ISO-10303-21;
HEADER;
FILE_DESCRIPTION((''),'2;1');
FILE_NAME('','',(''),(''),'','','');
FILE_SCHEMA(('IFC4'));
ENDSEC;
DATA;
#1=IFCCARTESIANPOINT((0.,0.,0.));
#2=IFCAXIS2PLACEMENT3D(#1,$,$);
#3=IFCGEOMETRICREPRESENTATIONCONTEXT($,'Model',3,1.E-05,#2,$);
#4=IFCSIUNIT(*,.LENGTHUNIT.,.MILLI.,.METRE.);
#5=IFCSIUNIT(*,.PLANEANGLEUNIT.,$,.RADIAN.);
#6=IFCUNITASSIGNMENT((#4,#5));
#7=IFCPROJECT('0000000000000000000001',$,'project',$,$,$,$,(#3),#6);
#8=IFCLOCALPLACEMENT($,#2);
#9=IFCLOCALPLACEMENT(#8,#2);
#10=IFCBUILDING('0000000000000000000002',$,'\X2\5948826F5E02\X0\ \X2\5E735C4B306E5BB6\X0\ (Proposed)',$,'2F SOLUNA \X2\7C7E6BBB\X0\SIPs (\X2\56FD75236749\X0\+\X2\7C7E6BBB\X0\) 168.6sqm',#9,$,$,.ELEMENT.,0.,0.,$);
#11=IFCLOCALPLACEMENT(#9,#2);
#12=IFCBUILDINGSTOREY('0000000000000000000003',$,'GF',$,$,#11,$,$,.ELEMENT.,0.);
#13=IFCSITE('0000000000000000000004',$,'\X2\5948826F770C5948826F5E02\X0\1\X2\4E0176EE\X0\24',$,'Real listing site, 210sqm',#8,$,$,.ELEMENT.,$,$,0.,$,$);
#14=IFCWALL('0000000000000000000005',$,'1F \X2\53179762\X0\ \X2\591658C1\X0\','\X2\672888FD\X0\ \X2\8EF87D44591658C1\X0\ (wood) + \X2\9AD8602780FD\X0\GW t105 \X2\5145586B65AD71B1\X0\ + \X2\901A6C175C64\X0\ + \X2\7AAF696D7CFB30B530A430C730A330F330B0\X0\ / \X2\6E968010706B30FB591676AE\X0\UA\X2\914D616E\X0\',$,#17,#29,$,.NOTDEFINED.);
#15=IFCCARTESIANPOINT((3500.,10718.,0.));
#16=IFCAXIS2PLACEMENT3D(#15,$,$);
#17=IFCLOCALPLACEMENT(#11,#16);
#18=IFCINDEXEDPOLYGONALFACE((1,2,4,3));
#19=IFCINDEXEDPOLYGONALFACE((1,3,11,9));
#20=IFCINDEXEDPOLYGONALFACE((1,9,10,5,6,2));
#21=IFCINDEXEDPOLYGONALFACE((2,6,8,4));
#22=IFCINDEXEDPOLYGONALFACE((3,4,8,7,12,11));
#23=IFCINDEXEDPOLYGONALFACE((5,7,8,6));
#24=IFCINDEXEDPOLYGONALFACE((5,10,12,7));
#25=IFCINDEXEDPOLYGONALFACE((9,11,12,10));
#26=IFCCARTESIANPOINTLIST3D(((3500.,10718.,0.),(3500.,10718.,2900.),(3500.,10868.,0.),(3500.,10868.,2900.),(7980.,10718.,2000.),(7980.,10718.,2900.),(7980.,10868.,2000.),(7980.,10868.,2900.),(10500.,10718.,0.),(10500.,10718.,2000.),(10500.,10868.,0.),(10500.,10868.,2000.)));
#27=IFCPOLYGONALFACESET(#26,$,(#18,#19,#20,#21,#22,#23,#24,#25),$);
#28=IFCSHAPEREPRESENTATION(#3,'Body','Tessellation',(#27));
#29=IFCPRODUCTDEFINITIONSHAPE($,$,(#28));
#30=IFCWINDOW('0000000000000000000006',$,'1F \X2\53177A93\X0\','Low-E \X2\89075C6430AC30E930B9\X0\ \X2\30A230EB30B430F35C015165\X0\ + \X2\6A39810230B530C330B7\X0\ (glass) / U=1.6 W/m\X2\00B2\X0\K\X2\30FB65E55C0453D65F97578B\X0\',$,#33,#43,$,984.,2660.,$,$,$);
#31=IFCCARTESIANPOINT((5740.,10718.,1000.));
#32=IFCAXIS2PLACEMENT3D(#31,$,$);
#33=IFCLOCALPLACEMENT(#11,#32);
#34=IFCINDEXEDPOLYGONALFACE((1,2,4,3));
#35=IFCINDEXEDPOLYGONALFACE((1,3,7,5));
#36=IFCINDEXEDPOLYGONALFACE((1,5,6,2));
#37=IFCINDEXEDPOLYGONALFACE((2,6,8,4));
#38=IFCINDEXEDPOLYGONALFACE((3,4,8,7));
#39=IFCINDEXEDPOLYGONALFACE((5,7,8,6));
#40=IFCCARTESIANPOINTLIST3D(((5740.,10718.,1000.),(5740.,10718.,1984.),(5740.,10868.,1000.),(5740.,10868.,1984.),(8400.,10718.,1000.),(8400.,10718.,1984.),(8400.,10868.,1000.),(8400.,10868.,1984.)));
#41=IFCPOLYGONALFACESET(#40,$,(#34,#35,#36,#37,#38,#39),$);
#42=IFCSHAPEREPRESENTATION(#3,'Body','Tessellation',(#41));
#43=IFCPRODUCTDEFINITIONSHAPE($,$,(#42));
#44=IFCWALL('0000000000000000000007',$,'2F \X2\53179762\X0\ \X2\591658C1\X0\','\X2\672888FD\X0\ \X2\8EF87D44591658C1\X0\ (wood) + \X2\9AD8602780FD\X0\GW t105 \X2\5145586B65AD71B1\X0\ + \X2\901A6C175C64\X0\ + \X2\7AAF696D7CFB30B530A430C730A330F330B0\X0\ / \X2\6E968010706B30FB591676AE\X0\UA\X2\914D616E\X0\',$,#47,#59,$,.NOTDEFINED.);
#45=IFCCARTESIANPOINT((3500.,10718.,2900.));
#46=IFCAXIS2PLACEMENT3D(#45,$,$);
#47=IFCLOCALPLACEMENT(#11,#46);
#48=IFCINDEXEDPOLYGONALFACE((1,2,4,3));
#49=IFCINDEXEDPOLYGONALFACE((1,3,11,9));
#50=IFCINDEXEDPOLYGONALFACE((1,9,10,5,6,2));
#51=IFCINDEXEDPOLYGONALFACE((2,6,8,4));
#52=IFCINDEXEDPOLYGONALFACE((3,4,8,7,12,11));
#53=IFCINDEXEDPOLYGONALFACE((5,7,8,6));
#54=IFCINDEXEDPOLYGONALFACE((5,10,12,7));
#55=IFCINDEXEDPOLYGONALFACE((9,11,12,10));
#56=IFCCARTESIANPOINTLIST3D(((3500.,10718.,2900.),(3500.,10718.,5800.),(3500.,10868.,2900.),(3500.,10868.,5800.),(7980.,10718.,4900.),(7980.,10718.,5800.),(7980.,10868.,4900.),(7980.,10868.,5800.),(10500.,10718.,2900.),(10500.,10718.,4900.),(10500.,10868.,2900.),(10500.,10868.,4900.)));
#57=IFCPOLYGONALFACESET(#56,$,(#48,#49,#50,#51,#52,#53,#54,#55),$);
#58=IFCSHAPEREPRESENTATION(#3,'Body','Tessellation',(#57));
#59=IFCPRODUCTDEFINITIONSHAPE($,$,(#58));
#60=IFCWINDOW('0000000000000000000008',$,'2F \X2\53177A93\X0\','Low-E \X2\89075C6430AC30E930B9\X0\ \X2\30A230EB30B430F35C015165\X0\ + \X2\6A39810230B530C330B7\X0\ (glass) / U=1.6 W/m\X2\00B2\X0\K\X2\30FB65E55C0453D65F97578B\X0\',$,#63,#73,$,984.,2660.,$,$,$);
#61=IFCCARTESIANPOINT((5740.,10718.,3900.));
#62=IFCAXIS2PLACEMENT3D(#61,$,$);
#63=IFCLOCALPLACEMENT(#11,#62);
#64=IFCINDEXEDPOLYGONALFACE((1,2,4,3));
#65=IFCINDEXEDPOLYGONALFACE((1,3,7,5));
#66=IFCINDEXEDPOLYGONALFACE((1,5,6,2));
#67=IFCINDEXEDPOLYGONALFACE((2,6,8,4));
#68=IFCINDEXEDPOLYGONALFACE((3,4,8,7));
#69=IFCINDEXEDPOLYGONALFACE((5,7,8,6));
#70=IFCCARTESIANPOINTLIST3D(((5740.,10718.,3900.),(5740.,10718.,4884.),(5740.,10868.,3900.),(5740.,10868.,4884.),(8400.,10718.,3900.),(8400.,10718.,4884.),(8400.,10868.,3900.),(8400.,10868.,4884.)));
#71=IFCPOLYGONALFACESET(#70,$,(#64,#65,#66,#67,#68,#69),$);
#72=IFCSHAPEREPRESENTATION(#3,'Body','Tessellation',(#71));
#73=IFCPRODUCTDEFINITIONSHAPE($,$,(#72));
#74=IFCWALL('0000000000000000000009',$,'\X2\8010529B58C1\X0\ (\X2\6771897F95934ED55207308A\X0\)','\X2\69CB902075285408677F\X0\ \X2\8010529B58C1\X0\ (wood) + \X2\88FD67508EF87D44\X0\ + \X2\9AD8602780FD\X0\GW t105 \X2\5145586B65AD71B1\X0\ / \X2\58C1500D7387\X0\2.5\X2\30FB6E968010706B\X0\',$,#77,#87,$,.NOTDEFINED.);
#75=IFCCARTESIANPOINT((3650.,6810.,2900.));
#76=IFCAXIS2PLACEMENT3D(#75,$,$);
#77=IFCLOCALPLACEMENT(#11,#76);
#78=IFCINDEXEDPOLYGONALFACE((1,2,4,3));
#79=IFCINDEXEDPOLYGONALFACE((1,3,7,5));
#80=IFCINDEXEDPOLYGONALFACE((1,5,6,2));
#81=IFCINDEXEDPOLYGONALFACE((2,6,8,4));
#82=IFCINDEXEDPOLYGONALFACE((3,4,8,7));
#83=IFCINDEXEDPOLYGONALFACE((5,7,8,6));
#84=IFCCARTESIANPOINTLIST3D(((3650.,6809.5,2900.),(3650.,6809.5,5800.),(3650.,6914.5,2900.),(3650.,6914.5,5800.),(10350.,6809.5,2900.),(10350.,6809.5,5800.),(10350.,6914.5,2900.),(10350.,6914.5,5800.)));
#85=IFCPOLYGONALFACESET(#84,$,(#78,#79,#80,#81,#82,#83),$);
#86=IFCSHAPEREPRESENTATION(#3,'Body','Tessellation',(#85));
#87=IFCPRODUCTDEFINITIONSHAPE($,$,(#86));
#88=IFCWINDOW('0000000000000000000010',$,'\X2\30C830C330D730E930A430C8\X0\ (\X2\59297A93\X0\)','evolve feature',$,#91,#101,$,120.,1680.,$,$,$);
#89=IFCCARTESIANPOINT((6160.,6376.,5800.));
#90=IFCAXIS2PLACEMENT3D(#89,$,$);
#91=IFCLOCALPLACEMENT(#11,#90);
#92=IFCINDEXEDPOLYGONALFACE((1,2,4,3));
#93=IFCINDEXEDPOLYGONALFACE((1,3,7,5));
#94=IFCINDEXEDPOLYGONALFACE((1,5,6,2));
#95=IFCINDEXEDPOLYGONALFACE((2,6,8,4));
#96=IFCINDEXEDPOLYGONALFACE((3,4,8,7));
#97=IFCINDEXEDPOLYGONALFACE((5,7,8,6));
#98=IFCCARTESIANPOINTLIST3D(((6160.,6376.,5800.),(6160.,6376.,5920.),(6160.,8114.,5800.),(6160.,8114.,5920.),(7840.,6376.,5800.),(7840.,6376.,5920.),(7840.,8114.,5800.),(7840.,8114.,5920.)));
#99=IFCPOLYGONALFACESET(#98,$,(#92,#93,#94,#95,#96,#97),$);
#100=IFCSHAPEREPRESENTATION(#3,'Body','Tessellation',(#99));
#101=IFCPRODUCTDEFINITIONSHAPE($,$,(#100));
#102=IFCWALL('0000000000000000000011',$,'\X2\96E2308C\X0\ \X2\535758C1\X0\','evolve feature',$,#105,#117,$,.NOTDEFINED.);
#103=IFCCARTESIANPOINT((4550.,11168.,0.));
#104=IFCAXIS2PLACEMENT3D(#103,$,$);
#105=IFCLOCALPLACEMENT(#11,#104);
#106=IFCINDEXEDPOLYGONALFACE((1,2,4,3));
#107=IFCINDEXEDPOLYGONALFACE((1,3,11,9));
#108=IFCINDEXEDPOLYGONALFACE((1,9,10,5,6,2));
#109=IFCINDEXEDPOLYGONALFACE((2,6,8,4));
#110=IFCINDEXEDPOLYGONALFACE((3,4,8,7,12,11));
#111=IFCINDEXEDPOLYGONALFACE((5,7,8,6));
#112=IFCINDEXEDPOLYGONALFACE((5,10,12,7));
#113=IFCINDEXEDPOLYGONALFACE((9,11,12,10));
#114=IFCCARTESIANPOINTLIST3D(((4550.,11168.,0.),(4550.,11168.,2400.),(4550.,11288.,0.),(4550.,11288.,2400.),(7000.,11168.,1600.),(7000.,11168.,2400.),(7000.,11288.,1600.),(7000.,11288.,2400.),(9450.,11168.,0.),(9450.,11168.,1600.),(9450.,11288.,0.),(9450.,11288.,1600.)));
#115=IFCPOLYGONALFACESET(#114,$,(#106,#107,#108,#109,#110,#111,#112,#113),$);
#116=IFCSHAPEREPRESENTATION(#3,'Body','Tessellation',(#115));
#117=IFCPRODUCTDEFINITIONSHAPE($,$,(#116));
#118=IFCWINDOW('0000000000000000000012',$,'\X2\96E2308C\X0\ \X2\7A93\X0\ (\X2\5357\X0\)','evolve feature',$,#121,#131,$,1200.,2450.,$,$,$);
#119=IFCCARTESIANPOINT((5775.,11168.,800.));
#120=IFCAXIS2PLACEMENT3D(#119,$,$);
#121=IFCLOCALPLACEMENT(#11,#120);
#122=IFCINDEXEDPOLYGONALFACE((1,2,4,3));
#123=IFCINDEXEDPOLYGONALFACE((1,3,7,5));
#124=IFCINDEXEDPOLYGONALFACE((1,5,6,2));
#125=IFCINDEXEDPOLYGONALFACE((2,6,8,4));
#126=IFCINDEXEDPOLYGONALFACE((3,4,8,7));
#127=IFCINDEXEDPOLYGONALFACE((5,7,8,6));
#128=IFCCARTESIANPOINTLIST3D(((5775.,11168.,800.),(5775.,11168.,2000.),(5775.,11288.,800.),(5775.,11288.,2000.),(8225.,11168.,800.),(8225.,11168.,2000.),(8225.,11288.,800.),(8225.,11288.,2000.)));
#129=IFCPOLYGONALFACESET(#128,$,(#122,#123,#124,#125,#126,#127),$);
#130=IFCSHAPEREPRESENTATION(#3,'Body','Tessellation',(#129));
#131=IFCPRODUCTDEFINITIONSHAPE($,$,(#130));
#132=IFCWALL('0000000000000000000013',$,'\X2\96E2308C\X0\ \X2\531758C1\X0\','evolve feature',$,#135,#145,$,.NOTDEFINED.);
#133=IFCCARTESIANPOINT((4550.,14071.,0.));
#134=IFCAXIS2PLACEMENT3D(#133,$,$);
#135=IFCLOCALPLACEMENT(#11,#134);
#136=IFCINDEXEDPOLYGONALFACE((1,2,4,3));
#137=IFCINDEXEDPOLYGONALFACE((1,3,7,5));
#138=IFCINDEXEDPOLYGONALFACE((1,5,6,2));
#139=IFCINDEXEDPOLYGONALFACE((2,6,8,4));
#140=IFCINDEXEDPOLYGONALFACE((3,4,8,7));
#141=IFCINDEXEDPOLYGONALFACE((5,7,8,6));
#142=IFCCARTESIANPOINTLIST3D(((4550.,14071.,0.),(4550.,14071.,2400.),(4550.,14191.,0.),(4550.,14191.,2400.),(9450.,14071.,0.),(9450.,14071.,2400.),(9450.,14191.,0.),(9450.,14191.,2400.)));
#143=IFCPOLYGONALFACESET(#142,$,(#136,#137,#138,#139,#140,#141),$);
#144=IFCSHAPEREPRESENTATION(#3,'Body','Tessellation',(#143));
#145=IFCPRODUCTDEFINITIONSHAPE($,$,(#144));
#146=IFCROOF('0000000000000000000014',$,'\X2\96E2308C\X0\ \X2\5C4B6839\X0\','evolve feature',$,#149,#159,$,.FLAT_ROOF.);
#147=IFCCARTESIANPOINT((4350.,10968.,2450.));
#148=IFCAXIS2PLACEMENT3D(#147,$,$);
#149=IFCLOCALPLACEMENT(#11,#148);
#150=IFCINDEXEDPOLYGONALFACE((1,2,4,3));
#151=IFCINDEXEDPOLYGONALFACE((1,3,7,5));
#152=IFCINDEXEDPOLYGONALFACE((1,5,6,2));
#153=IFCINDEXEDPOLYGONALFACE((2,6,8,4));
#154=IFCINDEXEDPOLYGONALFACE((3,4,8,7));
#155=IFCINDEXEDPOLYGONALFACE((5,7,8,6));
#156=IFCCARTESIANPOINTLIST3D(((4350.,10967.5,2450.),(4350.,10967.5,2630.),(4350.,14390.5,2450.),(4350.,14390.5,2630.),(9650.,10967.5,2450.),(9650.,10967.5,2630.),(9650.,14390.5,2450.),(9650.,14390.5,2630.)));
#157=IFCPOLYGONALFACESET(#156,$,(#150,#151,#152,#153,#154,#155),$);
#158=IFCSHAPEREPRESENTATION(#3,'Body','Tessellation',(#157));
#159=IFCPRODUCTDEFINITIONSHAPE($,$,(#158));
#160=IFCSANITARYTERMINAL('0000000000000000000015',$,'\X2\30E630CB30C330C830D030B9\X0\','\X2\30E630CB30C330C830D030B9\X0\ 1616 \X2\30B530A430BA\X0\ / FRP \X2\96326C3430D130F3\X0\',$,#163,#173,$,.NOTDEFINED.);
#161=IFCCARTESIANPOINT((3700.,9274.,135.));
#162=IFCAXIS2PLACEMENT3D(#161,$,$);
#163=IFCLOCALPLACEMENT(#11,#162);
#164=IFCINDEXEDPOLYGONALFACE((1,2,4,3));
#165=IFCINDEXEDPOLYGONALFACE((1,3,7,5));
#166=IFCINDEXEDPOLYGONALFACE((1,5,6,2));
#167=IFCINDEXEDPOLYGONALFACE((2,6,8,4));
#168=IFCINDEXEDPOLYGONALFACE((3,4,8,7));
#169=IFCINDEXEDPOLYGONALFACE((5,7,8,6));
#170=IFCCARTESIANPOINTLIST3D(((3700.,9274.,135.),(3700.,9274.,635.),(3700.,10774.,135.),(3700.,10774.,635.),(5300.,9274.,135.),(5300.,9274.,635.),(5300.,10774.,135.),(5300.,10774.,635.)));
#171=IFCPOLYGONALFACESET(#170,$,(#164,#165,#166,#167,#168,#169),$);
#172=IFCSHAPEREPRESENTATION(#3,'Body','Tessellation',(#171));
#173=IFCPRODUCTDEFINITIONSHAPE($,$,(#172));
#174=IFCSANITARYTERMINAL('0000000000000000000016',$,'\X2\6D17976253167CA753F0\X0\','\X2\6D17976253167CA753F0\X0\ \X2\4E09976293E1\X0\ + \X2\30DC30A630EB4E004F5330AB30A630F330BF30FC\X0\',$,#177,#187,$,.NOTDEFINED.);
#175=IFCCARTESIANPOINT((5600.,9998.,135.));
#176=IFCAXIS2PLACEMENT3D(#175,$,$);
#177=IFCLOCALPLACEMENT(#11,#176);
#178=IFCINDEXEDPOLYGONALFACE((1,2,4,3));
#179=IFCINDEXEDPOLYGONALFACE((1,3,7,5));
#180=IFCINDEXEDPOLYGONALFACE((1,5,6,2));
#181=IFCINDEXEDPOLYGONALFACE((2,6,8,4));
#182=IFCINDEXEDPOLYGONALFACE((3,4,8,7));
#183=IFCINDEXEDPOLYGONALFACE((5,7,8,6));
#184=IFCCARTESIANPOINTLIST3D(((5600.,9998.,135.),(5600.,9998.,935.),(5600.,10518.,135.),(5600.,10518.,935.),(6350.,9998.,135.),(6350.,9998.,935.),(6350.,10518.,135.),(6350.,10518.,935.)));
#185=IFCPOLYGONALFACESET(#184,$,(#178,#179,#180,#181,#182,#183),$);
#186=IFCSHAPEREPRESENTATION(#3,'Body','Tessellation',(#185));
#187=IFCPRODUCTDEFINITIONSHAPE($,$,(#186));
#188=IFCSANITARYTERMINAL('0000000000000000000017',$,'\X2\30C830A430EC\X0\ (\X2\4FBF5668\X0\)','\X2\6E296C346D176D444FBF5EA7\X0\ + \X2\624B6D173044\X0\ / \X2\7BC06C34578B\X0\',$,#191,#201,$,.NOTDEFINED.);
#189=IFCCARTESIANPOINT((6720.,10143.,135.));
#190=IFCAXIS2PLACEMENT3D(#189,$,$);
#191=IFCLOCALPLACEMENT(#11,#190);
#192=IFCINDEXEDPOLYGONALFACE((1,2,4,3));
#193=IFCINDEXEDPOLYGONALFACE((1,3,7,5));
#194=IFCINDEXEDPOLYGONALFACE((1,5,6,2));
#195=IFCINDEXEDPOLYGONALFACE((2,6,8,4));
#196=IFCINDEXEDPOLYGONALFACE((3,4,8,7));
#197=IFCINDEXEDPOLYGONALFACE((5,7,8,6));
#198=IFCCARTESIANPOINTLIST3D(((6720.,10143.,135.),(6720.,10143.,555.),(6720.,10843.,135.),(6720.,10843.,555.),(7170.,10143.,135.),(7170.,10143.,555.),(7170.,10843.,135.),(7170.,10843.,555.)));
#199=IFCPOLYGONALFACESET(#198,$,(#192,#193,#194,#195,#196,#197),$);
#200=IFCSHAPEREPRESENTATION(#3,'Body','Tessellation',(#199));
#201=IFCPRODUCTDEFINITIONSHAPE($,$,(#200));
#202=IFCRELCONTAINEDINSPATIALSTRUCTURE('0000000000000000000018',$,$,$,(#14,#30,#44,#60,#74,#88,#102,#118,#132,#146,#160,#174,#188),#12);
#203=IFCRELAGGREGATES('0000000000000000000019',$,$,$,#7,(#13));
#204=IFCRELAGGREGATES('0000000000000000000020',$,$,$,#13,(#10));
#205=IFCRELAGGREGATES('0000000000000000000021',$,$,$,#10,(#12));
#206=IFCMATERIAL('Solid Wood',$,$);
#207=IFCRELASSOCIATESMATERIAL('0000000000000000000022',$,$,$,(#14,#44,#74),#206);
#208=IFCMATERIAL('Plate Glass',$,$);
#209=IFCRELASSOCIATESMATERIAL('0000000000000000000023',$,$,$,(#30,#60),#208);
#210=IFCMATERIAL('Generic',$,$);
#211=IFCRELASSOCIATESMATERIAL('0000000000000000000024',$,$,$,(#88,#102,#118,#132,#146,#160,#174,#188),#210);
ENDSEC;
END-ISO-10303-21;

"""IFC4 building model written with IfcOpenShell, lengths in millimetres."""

from ifc_helpers import new_model, si_unit, frame, frame_2d, origin, place, context, project, spatial, rectangle, extrude, material, element, fill, save


model = new_model("IFC4")

# Units and contexts
model_context = context("Model", 3, precision=1e-05, world=origin())
ifc_project = project(units=[si_unit("LENGTHUNIT", "METRE", prefix="MILLI"), si_unit("PLANEANGLEUNIT", "RADIAN")], contexts=[model_context])

# Site, building, storey
site_placement = place(None, origin())
site = spatial("IfcSite", under=ifc_project, at=site_placement, Name="奈良県奈良市1丁目24", ObjectType="Real listing site, 210sqm", CompositionType="ELEMENT", RefElevation=0.0)
building_placement = place(site_placement, origin())
building = spatial("IfcBuilding", under=site, at=building_placement, Name="奈良市 平屋の家 (Proposed)", ObjectType="2F SOLUNA 籾殻SIPs (国産杉+籾殻) 168.6sqm", CompositionType="ELEMENT", ElevationOfRefHeight=0.0, ElevationOfTerrain=0.0)
storey_placement = place(building_placement, origin())
storey = spatial("IfcBuildingStorey", under=building, at=storey_placement, Name="GF", CompositionType="ELEMENT", Elevation=0.0)

# Shared definitions
ifc_material_1 = material(Name="Generic")

# Wall, opening, window
ifc_material_2 = material(Name="Solid Wood")
wall_1_placement = place(storey_placement, frame((3500.0, 10718.0, 0.0)))
wall_1 = element("IfcWall", 1, at=wall_1_placement, inside=storey, material=ifc_material_2, Name="1F 北面 外壁", Description="木製 軸組外壁 (wood) + 高性能GW t105 充填断熱 + 通気層 + 窯業系サイディング / 準耐火・外皮UA配慮", PredefinedType="NOTDEFINED", context=model_context, shape_type="SweptSolid", body=[
    extrude(rectangle(XDim=7000.0, YDim=150.0, at=frame_2d((3500.0, 75.0))), frame((3500.0, 10718.0, 0.0)), (0.0, 0.0, 1.0), 2900.0),
])
opening_1_placement = place(storey_placement, frame((5740.0, 10718.0, 1000.0)))
opening_1 = element("IfcOpeningElement", 2, at=opening_1_placement, cuts=wall_1, PredefinedType="NOTDEFINED", context=model_context, shape_type="SweptSolid", body=[
    extrude(rectangle(XDim=2660.0, YDim=150.0, at=frame_2d((1330.0, 75.0))), frame((5740.0, 10718.0, 1000.0)), (0.0, 0.0, 1.0), 984.0),
])
ifc_material_3 = material(Name="Plate Glass")
window_1_placement = place(storey_placement, frame((5740.0, 10718.0, 1000.0)))
window_1 = element("IfcWindow", 3, at=window_1_placement, inside=storey, material=ifc_material_3, Name="1F 北窓", Description="Low-E 複層ガラス アルゴン封入 + 樹脂サッシ (glass) / U=1.6 W/m²K・日射取得型", OverallHeight=984.0, OverallWidth=2660.0, context=model_context, shape_type="SweptSolid", body=[
    extrude(rectangle(XDim=2660.0, YDim=150.0, at=frame_2d((1330.0, 75.0))), frame((5740.0, 10718.0, 1000.0)), (0.0, 0.0, 1.0), 984.0),
])
fill(opening_1, window_1)

# Wall, opening, window
wall_2_placement = place(storey_placement, frame((3500.0, 10718.0, 2900.0)))
wall_2 = element("IfcWall", 4, at=wall_2_placement, inside=storey, material=ifc_material_2, Name="2F 北面 外壁", Description="木製 軸組外壁 (wood) + 高性能GW t105 充填断熱 + 通気層 + 窯業系サイディング / 準耐火・外皮UA配慮", PredefinedType="NOTDEFINED", context=model_context, shape_type="SweptSolid", body=[
    extrude(rectangle(XDim=7000.0, YDim=150.0, at=frame_2d((3500.0, 75.0))), frame((3500.0, 10718.0, 2900.0)), (0.0, 0.0, 1.0), 2900.0),
])
opening_2_placement = place(storey_placement, frame((5740.0, 10718.0, 3900.0)))
opening_2 = element("IfcOpeningElement", 5, at=opening_2_placement, cuts=wall_2, PredefinedType="NOTDEFINED", context=model_context, shape_type="SweptSolid", body=[
    extrude(rectangle(XDim=2660.0, YDim=150.0, at=frame_2d((1330.0, 75.0))), frame((5740.0, 10718.0, 3900.0)), (0.0, 0.0, 1.0), 984.0),
])
window_2_placement = place(storey_placement, frame((5740.0, 10718.0, 3900.0)))
window_2 = element("IfcWindow", 6, at=window_2_placement, inside=storey, material=ifc_material_3, Name="2F 北窓", Description="Low-E 複層ガラス アルゴン封入 + 樹脂サッシ (glass) / U=1.6 W/m²K・日射取得型", OverallHeight=984.0, OverallWidth=2660.0, context=model_context, shape_type="SweptSolid", body=[
    extrude(rectangle(XDim=2660.0, YDim=150.0, at=frame_2d((1330.0, 75.0))), frame((5740.0, 10718.0, 3900.0)), (0.0, 0.0, 1.0), 984.0),
])
fill(opening_2, window_2)

# Wall
wall_3_placement = place(storey_placement, frame((3650.0, 6810.0, 2900.0)))
element("IfcWall", 7, at=wall_3_placement, inside=storey, material=ifc_material_2, Name="耐力壁 (東西間仕切り)", Description="構造用合板 耐力壁 (wood) + 製材軸組 + 高性能GW t105 充填断熱 / 壁倍率2.5・準耐火", PredefinedType="NOTDEFINED", context=model_context, shape_type="SweptSolid", body=[
    extrude(rectangle(XDim=6700.0, YDim=105.0, at=frame_2d((3350.0, 52.0))), frame((3650.0, 6810.0, 2900.0)), (0.0, 0.0, 1.0), 2900.0),
])

# Window
window_3_placement = place(storey_placement, frame((6160.0, 6376.0, 5800.0)))
element("IfcWindow", 8, at=window_3_placement, inside=storey, material=ifc_material_1, Name="トップライト (天窓)", Description="evolve feature", OverallHeight=120.0, OverallWidth=1680.0, context=model_context, shape_type="SweptSolid", body=[
    extrude(rectangle(XDim=1680.0, YDim=1738.0, at=frame_2d((840.0, 869.0))), frame((6160.0, 6376.0, 5800.0)), (0.0, 0.0, 1.0), 120.0),
])

# Wall, opening, window
wall_4_placement = place(storey_placement, frame((4550.0, 11168.0, 0.0)))
wall_4 = element("IfcWall", 9, at=wall_4_placement, inside=storey, material=ifc_material_1, Name="離れ 南壁", Description="evolve feature", PredefinedType="NOTDEFINED", context=model_context, shape_type="SweptSolid", body=[
    extrude(rectangle(XDim=4900.0, YDim=120.0, at=frame_2d((2450.0, 60.0))), frame((4550.0, 11168.0, 0.0)), (0.0, 0.0, 1.0), 2400.0),
])
opening_3_placement = place(storey_placement, frame((5775.0, 11168.0, 800.0)))
opening_3 = element("IfcOpeningElement", 10, at=opening_3_placement, cuts=wall_4, PredefinedType="NOTDEFINED", context=model_context, shape_type="SweptSolid", body=[
    extrude(rectangle(XDim=2450.0, YDim=120.0, at=frame_2d((1225.0, 60.0))), frame((5775.0, 11168.0, 800.0)), (0.0, 0.0, 1.0), 1200.0),
])
window_4_placement = place(storey_placement, frame((5775.0, 11168.0, 800.0)))
window_4 = element("IfcWindow", 11, at=window_4_placement, inside=storey, material=ifc_material_1, Name="離れ 窓 (南)", Description="evolve feature", OverallHeight=1200.0, OverallWidth=2450.0, context=model_context, shape_type="SweptSolid", body=[
    extrude(rectangle(XDim=2450.0, YDim=120.0, at=frame_2d((1225.0, 60.0))), frame((5775.0, 11168.0, 800.0)), (0.0, 0.0, 1.0), 1200.0),
])
fill(opening_3, window_4)

# Wall
wall_5_placement = place(storey_placement, frame((4550.0, 14071.0, 0.0)))
element("IfcWall", 12, at=wall_5_placement, inside=storey, material=ifc_material_1, Name="離れ 北壁", Description="evolve feature", PredefinedType="NOTDEFINED", context=model_context, shape_type="SweptSolid", body=[
    extrude(rectangle(XDim=4900.0, YDim=120.0, at=frame_2d((2450.0, 60.0))), frame((4550.0, 14071.0, 0.0)), (0.0, 0.0, 1.0), 2400.0),
])

# Roof
roof_placement = place(storey_placement, frame((4350.0, 10968.0, 2450.0)))
element("IfcRoof", 13, at=roof_placement, inside=storey, material=ifc_material_1, Name="離れ 屋根", Description="evolve feature", PredefinedType="FLAT_ROOF", context=model_context, shape_type="SweptSolid", body=[
    extrude(rectangle(XDim=5300.0, YDim=3423.0, at=frame_2d((2650.0, 1711.0))), frame((4350.0, 10968.0, 2450.0)), (0.0, 0.0, 1.0), 180.0),
])

# Sanitary terminals
sanitary_terminal_1_placement = place(storey_placement, frame((3700.0, 9274.0, 135.0)))
element("IfcSanitaryTerminal", 14, at=sanitary_terminal_1_placement, inside=storey, material=ifc_material_1, Name="ユニットバス", Description="ユニットバス 1616 サイズ / FRP 防水パン", PredefinedType="NOTDEFINED", context=model_context, shape_type="SweptSolid", body=[
    extrude(rectangle(XDim=1600.0, YDim=1500.0, at=frame_2d((800.0, 750.0))), frame((3700.0, 9274.0, 135.0)), (0.0, 0.0, 1.0), 500.0),
])
sanitary_terminal_2_placement = place(storey_placement, frame((5600.0, 9998.0, 135.0)))
element("IfcSanitaryTerminal", 15, at=sanitary_terminal_2_placement, inside=storey, material=ifc_material_1, Name="洗面化粧台", Description="洗面化粧台 三面鏡 + ボウル一体カウンター", PredefinedType="NOTDEFINED", context=model_context, shape_type="SweptSolid", body=[
    extrude(rectangle(XDim=750.0, YDim=520.0, at=frame_2d((375.0, 260.0))), frame((5600.0, 9998.0, 135.0)), (0.0, 0.0, 1.0), 800.0),
])
sanitary_terminal_3_placement = place(storey_placement, frame((6720.0, 10143.0, 135.0)))
element("IfcSanitaryTerminal", 16, at=sanitary_terminal_3_placement, inside=storey, material=ifc_material_1, Name="トイレ (便器)", Description="温水洗浄便座 + 手洗い / 節水型", PredefinedType="NOTDEFINED", context=model_context, shape_type="SweptSolid", body=[
    extrude(rectangle(XDim=450.0, YDim=700.0, at=frame_2d((225.0, 350.0))), frame((6720.0, 10143.0, 135.0)), (0.0, 0.0, 1.0), 420.0),
])

save(model, "model.ifc")
